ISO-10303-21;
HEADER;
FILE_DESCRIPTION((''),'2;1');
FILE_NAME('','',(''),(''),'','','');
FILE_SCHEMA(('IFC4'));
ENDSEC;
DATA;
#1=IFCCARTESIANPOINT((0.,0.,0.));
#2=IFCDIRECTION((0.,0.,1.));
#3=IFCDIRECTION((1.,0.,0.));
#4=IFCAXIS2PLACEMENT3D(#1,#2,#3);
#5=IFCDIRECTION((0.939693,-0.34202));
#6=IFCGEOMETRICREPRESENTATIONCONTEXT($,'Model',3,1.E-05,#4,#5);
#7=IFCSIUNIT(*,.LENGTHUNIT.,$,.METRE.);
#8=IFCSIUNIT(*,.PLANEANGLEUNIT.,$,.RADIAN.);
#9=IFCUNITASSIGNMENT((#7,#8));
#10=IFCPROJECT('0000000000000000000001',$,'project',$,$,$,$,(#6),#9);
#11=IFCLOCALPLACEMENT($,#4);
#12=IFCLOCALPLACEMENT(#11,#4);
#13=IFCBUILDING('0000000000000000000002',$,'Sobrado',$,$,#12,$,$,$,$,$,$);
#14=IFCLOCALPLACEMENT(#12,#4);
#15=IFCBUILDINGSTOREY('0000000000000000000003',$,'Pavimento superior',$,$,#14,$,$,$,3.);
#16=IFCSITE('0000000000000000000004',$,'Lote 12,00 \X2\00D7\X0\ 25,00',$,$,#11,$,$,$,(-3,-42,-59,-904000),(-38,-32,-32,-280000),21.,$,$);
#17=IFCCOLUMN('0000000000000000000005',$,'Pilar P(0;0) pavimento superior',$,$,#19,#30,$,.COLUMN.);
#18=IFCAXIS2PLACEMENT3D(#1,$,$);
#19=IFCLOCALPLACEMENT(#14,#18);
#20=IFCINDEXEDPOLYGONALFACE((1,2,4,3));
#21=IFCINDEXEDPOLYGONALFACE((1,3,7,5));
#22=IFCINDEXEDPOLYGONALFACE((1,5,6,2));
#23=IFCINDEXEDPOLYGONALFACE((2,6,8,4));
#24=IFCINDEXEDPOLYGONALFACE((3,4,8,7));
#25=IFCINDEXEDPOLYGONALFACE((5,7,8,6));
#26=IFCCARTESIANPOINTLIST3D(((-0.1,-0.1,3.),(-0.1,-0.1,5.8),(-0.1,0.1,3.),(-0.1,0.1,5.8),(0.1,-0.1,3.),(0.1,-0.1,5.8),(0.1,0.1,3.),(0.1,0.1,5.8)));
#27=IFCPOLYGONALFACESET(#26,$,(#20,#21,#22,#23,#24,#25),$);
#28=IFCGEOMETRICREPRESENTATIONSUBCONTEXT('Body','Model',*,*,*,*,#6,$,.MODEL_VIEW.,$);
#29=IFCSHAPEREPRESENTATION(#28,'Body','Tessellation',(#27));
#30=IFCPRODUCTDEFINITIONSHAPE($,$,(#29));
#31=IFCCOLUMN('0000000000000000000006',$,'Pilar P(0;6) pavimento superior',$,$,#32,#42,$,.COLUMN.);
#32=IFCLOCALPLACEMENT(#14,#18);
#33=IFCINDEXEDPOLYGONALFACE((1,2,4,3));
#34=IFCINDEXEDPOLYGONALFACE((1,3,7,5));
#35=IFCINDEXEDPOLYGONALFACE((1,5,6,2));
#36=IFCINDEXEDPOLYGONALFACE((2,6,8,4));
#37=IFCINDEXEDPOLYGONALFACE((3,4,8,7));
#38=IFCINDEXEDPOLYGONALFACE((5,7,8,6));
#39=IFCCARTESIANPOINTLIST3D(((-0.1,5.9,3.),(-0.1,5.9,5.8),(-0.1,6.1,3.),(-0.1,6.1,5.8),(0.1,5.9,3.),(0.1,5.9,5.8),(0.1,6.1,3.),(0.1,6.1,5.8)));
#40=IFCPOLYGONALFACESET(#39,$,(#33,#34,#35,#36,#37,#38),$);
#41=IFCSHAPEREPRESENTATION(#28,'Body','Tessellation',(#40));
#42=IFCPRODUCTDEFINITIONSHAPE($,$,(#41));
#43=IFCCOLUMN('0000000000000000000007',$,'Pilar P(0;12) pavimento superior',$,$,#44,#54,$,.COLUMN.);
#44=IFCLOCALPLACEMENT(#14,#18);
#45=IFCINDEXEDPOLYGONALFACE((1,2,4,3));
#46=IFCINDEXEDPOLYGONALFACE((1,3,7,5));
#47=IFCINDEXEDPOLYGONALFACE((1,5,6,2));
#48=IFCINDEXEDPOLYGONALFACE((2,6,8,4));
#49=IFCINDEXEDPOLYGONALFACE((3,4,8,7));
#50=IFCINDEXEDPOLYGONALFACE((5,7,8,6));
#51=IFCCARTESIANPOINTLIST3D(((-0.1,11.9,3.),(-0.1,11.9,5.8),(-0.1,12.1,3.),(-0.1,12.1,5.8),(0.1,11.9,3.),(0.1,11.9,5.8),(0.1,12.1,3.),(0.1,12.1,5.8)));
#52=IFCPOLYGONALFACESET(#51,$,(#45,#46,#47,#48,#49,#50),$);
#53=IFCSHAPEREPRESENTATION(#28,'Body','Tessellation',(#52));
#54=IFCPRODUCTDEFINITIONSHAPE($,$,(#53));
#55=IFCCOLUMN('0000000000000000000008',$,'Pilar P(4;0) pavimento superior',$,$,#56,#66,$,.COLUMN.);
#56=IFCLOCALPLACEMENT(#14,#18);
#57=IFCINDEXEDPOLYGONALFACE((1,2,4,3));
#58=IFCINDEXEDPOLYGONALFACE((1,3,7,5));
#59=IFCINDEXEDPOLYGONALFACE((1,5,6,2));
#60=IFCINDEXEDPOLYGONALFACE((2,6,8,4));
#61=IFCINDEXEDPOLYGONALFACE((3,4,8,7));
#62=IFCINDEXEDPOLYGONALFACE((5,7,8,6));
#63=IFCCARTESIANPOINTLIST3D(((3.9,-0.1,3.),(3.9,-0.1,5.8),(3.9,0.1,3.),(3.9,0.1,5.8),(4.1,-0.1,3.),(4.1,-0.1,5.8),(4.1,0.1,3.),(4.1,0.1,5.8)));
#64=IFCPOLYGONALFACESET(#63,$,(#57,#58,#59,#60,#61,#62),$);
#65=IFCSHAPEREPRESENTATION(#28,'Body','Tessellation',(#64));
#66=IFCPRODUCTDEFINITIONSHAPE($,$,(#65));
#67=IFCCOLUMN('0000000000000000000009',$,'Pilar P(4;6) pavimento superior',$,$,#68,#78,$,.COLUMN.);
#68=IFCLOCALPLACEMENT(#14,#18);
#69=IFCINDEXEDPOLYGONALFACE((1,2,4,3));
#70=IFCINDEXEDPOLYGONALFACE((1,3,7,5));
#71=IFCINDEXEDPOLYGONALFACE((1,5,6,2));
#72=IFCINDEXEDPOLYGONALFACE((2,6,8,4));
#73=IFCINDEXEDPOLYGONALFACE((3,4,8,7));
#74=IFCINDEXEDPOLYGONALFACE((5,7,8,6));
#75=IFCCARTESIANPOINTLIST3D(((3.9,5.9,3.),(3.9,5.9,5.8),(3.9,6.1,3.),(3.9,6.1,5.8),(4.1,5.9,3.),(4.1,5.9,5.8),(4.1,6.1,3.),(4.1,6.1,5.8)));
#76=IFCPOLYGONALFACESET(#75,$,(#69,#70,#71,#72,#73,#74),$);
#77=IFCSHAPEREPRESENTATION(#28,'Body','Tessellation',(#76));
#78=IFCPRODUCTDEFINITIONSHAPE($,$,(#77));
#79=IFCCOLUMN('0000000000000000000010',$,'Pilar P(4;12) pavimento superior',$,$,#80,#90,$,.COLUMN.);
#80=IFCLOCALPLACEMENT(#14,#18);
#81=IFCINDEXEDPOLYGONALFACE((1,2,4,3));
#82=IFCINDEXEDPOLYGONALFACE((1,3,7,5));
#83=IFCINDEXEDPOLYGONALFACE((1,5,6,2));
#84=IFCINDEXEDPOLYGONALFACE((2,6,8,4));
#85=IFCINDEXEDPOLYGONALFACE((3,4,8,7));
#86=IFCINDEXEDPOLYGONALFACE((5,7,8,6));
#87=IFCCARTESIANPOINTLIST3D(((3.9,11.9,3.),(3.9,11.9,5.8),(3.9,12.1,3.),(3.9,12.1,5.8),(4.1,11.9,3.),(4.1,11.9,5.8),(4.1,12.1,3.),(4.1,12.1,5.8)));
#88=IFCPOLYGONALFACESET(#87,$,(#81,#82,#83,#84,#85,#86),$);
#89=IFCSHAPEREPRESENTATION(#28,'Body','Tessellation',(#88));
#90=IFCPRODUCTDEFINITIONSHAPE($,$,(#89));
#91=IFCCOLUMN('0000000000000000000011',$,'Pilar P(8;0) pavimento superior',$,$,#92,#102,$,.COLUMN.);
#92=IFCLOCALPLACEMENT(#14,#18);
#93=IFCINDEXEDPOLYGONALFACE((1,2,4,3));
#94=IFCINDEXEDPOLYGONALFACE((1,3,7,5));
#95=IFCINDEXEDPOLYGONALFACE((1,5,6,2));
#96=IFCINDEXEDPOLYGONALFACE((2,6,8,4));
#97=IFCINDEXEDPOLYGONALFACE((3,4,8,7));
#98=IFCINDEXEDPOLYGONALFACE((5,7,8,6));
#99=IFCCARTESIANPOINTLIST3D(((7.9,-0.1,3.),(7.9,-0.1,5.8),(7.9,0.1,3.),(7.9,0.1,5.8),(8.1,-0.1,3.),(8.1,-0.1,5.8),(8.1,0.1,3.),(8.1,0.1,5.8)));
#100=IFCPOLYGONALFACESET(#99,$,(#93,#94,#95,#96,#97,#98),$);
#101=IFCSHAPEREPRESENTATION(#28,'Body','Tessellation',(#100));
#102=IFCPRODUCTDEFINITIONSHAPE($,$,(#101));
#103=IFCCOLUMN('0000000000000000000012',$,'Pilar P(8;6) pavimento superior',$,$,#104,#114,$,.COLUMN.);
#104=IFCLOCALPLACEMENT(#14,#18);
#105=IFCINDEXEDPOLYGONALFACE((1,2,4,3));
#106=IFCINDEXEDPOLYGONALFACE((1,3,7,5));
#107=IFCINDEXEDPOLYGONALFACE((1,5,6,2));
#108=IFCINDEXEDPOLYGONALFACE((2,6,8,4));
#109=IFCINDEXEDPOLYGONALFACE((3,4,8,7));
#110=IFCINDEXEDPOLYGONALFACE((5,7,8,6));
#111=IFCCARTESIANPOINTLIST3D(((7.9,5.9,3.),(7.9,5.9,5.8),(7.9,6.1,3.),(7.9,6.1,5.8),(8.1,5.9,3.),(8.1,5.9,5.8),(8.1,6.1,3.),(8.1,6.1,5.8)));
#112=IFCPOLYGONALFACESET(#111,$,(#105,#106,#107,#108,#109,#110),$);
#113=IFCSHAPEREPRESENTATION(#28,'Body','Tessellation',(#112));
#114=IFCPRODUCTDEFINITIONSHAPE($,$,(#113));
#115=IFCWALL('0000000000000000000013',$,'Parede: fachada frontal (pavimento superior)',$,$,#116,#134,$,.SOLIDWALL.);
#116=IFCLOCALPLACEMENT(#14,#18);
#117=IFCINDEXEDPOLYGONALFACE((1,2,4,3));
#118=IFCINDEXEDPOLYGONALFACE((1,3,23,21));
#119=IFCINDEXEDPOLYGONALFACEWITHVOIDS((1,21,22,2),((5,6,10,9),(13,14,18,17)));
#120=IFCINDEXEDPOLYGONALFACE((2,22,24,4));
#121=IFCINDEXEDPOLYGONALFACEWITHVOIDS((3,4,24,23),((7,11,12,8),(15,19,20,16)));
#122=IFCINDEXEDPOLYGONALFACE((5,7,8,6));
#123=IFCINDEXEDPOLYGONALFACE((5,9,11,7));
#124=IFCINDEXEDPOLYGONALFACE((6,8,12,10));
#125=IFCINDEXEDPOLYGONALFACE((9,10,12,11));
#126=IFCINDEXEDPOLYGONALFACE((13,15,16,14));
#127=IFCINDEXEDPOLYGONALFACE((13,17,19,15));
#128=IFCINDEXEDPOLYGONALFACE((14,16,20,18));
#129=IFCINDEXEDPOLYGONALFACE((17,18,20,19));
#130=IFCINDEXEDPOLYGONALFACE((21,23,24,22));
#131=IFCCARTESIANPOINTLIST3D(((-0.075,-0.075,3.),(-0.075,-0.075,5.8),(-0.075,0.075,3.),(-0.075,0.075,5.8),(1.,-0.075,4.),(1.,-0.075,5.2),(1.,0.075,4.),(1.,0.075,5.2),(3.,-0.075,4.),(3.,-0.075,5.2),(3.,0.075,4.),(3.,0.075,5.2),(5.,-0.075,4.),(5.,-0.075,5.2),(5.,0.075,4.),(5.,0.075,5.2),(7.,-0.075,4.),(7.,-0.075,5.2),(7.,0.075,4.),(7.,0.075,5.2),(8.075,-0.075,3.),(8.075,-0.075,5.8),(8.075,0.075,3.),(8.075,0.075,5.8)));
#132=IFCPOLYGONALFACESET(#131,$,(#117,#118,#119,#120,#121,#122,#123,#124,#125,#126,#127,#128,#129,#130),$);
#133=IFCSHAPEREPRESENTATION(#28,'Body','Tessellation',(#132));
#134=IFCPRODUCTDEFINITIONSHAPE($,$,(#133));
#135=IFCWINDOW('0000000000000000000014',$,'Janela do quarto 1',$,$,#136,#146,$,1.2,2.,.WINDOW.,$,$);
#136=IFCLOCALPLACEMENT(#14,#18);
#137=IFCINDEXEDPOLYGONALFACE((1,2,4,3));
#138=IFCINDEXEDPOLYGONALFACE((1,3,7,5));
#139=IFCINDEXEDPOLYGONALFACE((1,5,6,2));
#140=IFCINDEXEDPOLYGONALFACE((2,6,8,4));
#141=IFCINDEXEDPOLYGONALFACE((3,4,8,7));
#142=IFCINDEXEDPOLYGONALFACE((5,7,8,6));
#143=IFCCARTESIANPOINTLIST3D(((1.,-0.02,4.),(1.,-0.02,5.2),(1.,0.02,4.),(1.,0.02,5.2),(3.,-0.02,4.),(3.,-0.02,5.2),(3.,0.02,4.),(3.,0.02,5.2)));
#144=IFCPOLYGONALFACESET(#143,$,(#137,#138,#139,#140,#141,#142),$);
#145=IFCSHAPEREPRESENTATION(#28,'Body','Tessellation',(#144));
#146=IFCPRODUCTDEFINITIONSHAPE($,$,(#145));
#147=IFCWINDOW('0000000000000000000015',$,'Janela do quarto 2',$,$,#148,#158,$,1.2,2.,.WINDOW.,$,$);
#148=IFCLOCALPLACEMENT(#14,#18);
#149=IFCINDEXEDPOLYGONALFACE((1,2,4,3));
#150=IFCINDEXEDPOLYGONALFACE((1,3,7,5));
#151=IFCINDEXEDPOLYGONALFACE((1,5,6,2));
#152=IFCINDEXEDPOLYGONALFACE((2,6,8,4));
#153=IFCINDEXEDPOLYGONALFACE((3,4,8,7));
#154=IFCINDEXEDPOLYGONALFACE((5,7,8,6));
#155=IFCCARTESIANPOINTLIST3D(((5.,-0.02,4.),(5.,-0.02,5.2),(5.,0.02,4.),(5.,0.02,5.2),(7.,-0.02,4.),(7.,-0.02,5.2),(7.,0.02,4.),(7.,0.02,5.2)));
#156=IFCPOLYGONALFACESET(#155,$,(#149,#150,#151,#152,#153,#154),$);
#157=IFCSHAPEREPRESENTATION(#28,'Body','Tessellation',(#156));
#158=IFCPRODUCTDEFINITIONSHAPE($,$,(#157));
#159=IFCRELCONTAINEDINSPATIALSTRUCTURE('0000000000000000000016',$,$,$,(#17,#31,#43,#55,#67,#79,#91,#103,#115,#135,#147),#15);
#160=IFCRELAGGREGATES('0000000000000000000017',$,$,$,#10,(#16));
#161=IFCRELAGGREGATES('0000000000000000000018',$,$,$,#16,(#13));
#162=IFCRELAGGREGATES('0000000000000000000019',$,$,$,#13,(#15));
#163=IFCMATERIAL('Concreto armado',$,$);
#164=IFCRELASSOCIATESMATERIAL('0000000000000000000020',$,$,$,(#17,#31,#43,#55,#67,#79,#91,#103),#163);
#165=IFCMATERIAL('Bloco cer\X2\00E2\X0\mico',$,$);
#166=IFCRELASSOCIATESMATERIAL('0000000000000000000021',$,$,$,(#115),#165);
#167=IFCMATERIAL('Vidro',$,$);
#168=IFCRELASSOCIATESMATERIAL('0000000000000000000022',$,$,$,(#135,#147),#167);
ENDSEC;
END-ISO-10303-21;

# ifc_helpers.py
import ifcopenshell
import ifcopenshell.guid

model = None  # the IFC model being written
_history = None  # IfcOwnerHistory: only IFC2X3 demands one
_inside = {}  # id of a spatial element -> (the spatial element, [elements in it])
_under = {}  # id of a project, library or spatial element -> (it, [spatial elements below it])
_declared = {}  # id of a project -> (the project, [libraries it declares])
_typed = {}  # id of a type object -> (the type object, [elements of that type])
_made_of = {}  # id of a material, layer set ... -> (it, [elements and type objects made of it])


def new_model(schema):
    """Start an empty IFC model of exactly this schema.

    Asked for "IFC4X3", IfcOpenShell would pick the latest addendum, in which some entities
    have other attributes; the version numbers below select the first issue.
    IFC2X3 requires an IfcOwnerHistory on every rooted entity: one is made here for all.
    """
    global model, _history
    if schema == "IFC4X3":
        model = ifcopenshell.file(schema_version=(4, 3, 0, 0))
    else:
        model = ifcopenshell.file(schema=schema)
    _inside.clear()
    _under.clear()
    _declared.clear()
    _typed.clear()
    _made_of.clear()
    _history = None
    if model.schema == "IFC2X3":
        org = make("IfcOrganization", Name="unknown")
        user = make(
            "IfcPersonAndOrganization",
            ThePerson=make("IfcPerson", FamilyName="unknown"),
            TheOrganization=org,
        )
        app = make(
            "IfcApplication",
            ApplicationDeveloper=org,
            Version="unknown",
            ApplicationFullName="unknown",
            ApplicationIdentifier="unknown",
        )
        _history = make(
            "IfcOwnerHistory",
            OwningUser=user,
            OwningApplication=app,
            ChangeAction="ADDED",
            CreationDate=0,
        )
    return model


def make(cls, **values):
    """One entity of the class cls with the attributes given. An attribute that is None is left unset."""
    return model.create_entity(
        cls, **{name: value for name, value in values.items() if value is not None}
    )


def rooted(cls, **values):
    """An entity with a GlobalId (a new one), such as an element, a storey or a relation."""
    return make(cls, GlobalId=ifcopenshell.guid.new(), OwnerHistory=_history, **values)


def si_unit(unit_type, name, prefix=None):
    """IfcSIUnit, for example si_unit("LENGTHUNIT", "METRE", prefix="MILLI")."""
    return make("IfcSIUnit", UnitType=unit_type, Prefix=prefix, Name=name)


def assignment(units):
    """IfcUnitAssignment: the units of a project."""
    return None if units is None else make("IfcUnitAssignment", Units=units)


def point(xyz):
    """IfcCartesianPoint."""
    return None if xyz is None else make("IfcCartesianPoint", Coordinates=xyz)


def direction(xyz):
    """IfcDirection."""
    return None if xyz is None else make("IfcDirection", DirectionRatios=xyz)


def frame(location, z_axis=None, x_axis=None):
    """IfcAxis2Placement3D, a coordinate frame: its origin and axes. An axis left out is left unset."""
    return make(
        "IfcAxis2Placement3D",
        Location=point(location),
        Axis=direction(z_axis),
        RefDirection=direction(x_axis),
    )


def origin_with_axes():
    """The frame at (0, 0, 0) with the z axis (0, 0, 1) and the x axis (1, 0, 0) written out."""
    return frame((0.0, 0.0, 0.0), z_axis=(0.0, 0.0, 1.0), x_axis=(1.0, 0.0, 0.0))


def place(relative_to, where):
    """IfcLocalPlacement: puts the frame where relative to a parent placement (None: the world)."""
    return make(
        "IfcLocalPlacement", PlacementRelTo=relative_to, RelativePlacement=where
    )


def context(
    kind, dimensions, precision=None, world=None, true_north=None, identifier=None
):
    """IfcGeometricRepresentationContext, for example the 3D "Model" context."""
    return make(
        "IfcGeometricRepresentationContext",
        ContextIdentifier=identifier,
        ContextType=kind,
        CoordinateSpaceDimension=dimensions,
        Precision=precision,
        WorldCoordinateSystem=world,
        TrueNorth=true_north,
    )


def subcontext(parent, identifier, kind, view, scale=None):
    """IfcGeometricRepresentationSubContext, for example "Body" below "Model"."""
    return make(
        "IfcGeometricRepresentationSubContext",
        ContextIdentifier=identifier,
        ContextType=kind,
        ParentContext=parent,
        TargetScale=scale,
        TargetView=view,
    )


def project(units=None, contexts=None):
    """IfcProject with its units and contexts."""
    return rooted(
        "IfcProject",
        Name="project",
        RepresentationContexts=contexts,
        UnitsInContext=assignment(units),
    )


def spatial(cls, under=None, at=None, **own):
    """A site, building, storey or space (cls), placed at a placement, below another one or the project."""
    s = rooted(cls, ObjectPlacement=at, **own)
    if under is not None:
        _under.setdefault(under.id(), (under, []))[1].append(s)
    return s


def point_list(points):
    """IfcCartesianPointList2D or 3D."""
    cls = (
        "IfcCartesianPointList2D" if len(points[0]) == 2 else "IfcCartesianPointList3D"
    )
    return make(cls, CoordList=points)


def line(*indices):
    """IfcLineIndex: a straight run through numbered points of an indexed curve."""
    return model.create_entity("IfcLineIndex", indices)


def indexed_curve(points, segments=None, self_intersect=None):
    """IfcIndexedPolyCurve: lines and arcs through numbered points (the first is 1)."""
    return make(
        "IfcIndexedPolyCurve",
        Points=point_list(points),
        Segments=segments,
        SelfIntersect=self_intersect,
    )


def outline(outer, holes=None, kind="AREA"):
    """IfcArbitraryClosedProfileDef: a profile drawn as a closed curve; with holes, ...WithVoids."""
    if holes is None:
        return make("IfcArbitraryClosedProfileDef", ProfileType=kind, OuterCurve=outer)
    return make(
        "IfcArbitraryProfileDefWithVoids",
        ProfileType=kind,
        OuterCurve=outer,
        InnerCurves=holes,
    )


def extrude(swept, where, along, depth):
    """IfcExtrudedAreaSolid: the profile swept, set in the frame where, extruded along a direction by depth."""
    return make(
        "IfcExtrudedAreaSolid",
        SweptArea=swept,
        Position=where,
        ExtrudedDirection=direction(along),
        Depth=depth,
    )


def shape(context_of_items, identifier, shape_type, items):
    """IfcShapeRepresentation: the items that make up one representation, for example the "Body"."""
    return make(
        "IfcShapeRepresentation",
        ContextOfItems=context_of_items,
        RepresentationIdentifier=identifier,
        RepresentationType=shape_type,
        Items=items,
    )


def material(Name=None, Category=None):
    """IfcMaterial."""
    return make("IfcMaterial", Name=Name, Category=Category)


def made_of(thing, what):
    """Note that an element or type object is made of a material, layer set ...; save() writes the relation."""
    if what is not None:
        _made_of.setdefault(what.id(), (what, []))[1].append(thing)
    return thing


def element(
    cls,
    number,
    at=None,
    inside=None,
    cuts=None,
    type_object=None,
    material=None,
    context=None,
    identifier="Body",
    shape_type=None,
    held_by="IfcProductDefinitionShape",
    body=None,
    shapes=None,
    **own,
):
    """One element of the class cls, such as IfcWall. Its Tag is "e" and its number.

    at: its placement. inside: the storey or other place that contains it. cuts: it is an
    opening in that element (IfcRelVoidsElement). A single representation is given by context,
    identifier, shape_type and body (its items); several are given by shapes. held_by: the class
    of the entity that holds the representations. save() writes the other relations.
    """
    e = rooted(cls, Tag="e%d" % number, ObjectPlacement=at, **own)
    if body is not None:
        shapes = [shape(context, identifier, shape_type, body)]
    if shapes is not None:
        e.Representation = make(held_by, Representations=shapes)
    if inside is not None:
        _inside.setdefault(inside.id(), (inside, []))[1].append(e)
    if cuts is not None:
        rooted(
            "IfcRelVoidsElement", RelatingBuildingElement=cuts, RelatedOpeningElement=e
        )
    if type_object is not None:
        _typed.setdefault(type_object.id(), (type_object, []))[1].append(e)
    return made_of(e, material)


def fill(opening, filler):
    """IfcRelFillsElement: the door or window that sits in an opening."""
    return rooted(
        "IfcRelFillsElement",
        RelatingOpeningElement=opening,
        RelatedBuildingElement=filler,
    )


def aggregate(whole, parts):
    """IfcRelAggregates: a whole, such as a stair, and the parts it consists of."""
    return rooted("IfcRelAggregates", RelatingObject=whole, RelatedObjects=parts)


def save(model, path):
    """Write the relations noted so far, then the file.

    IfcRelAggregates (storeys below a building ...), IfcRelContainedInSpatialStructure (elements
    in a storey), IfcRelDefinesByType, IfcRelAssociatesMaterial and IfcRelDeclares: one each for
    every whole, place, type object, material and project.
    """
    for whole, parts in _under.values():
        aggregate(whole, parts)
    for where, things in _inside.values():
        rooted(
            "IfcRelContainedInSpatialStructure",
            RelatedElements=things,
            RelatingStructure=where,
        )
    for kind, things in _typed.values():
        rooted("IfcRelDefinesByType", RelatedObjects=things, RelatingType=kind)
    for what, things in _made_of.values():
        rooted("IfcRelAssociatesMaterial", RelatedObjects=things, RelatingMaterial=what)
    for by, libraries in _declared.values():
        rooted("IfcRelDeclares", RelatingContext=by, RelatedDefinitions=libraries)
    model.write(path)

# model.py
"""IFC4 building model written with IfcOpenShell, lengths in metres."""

from ifc_helpers import new_model, si_unit, direction, frame, origin_with_axes, place, context, subcontext, project, spatial, line, indexed_curve, outline, extrude, material, element, fill, save


model = new_model("IFC4")

# Units and contexts
model_context = context("Model", 3, precision=1e-05, world=origin_with_axes(), true_north=direction((0.939693, -0.34202)))
body_context = subcontext(model_context, "Body", "Model", "MODEL_VIEW")
ifc_project = project(units=[si_unit("LENGTHUNIT", "METRE"), si_unit("PLANEANGLEUNIT", "RADIAN")], contexts=[model_context])

# Site, building, storey
site_placement = place(None, origin_with_axes())
site = spatial("IfcSite", under=ifc_project, at=site_placement, Name="Lote 12,00 × 25,00", RefLatitude=(-3, -42, -59, -904000), RefLongitude=(-38, -32, -32, -280000), RefElevation=21.0)
building_placement = place(site_placement, origin_with_axes())
building = spatial("IfcBuilding", under=site, at=building_placement, Name="Sobrado")
storey_placement = place(building_placement, origin_with_axes())
storey = spatial("IfcBuildingStorey", under=building, at=storey_placement, Name="Pavimento superior", Elevation=3.0)

# Columns
ifc_material_1 = material(Name="Concreto armado")
column_1_placement = place(storey_placement, origin_with_axes())
element("IfcColumn", 1, at=column_1_placement, inside=storey, material=ifc_material_1, Name="Pilar P(0;0) pavimento superior", PredefinedType="COLUMN", context=body_context, shape_type="SweptSolid", body=[
    extrude(outline(indexed_curve([(-0.1, -0.1), (0.1, -0.1), (0.1, 0.1), (-0.1, 0.1)], segments=[line(1, 2, 3, 4, 1)])), frame((0.0, 0.0, 3.0), z_axis=(0.0, 0.0, 1.0), x_axis=(1.0, 0.0, 0.0)), (0.0, 0.0, 1.0), 2.8),
])
column_2_placement = place(storey_placement, origin_with_axes())
element("IfcColumn", 2, at=column_2_placement, inside=storey, material=ifc_material_1, Name="Pilar P(0;6) pavimento superior", PredefinedType="COLUMN", context=body_context, shape_type="SweptSolid", body=[
    extrude(outline(indexed_curve([(-0.1, 5.9), (0.1, 5.9), (0.1, 6.1), (-0.1, 6.1)], segments=[line(1, 2, 3, 4, 1)])), frame((0.0, 0.0, 3.0), z_axis=(0.0, 0.0, 1.0), x_axis=(1.0, 0.0, 0.0)), (0.0, 0.0, 1.0), 2.8),
])
column_3_placement = place(storey_placement, origin_with_axes())
element("IfcColumn", 3, at=column_3_placement, inside=storey, material=ifc_material_1, Name="Pilar P(0;12) pavimento superior", PredefinedType="COLUMN", context=body_context, shape_type="SweptSolid", body=[
    extrude(outline(indexed_curve([(-0.1, 11.9), (0.1, 11.9), (0.1, 12.1), (-0.1, 12.1)], segments=[line(1, 2, 3, 4, 1)])), frame((0.0, 0.0, 3.0), z_axis=(0.0, 0.0, 1.0), x_axis=(1.0, 0.0, 0.0)), (0.0, 0.0, 1.0), 2.8),
])
column_4_placement = place(storey_placement, origin_with_axes())
element("IfcColumn", 4, at=column_4_placement, inside=storey, material=ifc_material_1, Name="Pilar P(4;0) pavimento superior", PredefinedType="COLUMN", context=body_context, shape_type="SweptSolid", body=[
    extrude(outline(indexed_curve([(3.9, -0.1), (4.1, -0.1), (4.1, 0.1), (3.9, 0.1)], segments=[line(1, 2, 3, 4, 1)])), frame((0.0, 0.0, 3.0), z_axis=(0.0, 0.0, 1.0), x_axis=(1.0, 0.0, 0.0)), (0.0, 0.0, 1.0), 2.8),
])
column_5_placement = place(storey_placement, origin_with_axes())
element("IfcColumn", 5, at=column_5_placement, inside=storey, material=ifc_material_1, Name="Pilar P(4;6) pavimento superior", PredefinedType="COLUMN", context=body_context, shape_type="SweptSolid", body=[
    extrude(outline(indexed_curve([(3.9, 5.9), (4.1, 5.9), (4.1, 6.1), (3.9, 6.1)], segments=[line(1, 2, 3, 4, 1)])), frame((0.0, 0.0, 3.0), z_axis=(0.0, 0.0, 1.0), x_axis=(1.0, 0.0, 0.0)), (0.0, 0.0, 1.0), 2.8),
])
column_6_placement = place(storey_placement, origin_with_axes())
element("IfcColumn", 6, at=column_6_placement, inside=storey, material=ifc_material_1, Name="Pilar P(4;12) pavimento superior", PredefinedType="COLUMN", context=body_context, shape_type="SweptSolid", body=[
    extrude(outline(indexed_curve([(3.9, 11.9), (4.1, 11.9), (4.1, 12.1), (3.9, 12.1)], segments=[line(1, 2, 3, 4, 1)])), frame((0.0, 0.0, 3.0), z_axis=(0.0, 0.0, 1.0), x_axis=(1.0, 0.0, 0.0)), (0.0, 0.0, 1.0), 2.8),
])
column_7_placement = place(storey_placement, origin_with_axes())
element("IfcColumn", 7, at=column_7_placement, inside=storey, material=ifc_material_1, Name="Pilar P(8;0) pavimento superior", PredefinedType="COLUMN", context=body_context, shape_type="SweptSolid", body=[
    extrude(outline(indexed_curve([(7.9, -0.1), (8.1, -0.1), (8.1, 0.1), (7.9, 0.1)], segments=[line(1, 2, 3, 4, 1)])), frame((0.0, 0.0, 3.0), z_axis=(0.0, 0.0, 1.0), x_axis=(1.0, 0.0, 0.0)), (0.0, 0.0, 1.0), 2.8),
])
column_8_placement = place(storey_placement, origin_with_axes())
element("IfcColumn", 8, at=column_8_placement, inside=storey, material=ifc_material_1, Name="Pilar P(8;6) pavimento superior", PredefinedType="COLUMN", context=body_context, shape_type="SweptSolid", body=[
    extrude(outline(indexed_curve([(7.9, 5.9), (8.1, 5.9), (8.1, 6.1), (7.9, 6.1)], segments=[line(1, 2, 3, 4, 1)])), frame((0.0, 0.0, 3.0), z_axis=(0.0, 0.0, 1.0), x_axis=(1.0, 0.0, 0.0)), (0.0, 0.0, 1.0), 2.8),
])

# Wall, openings, windows
ifc_material_2 = material(Name="Bloco cerâmico")
wall_1_placement = place(storey_placement, origin_with_axes())
wall_1 = element("IfcWall", 9, at=wall_1_placement, inside=storey, material=ifc_material_2, Name="Parede: fachada frontal (pavimento superior)", PredefinedType="SOLIDWALL", context=body_context, shape_type="SweptSolid", body=[
    extrude(outline(indexed_curve([(-0.075, -0.075), (8.075, -0.075), (8.075, 0.075), (-0.075, 0.075)], segments=[line(1, 2, 3, 4, 1)])), frame((0.0, 0.0, 3.0), z_axis=(0.0, 0.0, 1.0), x_axis=(1.0, 0.0, 0.0)), (0.0, 0.0, 1.0), 2.8),
])
opening_1_placement = place(wall_1_placement, origin_with_axes())
opening_1 = element("IfcOpeningElement", 10, at=opening_1_placement, cuts=wall_1, material=ifc_material_1, PredefinedType="OPENING", context=body_context, shape_type="SweptSolid", body=[
    extrude(outline(indexed_curve([(1.0, -0.125), (3.0, -0.125), (3.0, 0.125), (1.0, 0.125)], segments=[line(1, 2, 3, 4, 1)])), frame((0.0, 0.0, 4.0), z_axis=(0.0, 0.0, 1.0), x_axis=(1.0, 0.0, 0.0)), (0.0, 0.0, 1.0), 1.2),
])
opening_2_placement = place(wall_1_placement, origin_with_axes())
opening_2 = element("IfcOpeningElement", 11, at=opening_2_placement, cuts=wall_1, material=ifc_material_1, PredefinedType="OPENING", context=body_context, shape_type="SweptSolid", body=[
    extrude(outline(indexed_curve([(5.0, -0.125), (7.0, -0.125), (7.0, 0.125), (5.0, 0.125)], segments=[line(1, 2, 3, 4, 1)])), frame((0.0, 0.0, 4.0), z_axis=(0.0, 0.0, 1.0), x_axis=(1.0, 0.0, 0.0)), (0.0, 0.0, 1.0), 1.2),
])
ifc_material_3 = material(Name="Vidro")
window_1_placement = place(storey_placement, origin_with_axes())
window_1 = element("IfcWindow", 12, at=window_1_placement, inside=storey, material=ifc_material_3, Name="Janela do quarto 1", OverallHeight=1.2, OverallWidth=2.0, PredefinedType="WINDOW", context=body_context, shape_type="SweptSolid", body=[
    extrude(outline(indexed_curve([(1.0, -0.02), (3.0, -0.02), (3.0, 0.02), (1.0, 0.02)], segments=[line(1, 2, 3, 4, 1)])), frame((0.0, 0.0, 4.0), z_axis=(0.0, 0.0, 1.0), x_axis=(1.0, 0.0, 0.0)), (0.0, 0.0, 1.0), 1.2),
])
fill(opening_1, window_1)
window_2_placement = place(storey_placement, origin_with_axes())
window_2 = element("IfcWindow", 13, at=window_2_placement, inside=storey, material=ifc_material_3, Name="Janela do quarto 2", OverallHeight=1.2, OverallWidth=2.0, PredefinedType="WINDOW", context=body_context, shape_type="SweptSolid", body=[
    extrude(outline(indexed_curve([(5.0, -0.02), (7.0, -0.02), (7.0, 0.02), (5.0, 0.02)], segments=[line(1, 2, 3, 4, 1)])), frame((0.0, 0.0, 4.0), z_axis=(0.0, 0.0, 1.0), x_axis=(1.0, 0.0, 0.0)), (0.0, 0.0, 1.0), 1.2),
])
fill(opening_2, window_2)

save(model, "model.ifc")
